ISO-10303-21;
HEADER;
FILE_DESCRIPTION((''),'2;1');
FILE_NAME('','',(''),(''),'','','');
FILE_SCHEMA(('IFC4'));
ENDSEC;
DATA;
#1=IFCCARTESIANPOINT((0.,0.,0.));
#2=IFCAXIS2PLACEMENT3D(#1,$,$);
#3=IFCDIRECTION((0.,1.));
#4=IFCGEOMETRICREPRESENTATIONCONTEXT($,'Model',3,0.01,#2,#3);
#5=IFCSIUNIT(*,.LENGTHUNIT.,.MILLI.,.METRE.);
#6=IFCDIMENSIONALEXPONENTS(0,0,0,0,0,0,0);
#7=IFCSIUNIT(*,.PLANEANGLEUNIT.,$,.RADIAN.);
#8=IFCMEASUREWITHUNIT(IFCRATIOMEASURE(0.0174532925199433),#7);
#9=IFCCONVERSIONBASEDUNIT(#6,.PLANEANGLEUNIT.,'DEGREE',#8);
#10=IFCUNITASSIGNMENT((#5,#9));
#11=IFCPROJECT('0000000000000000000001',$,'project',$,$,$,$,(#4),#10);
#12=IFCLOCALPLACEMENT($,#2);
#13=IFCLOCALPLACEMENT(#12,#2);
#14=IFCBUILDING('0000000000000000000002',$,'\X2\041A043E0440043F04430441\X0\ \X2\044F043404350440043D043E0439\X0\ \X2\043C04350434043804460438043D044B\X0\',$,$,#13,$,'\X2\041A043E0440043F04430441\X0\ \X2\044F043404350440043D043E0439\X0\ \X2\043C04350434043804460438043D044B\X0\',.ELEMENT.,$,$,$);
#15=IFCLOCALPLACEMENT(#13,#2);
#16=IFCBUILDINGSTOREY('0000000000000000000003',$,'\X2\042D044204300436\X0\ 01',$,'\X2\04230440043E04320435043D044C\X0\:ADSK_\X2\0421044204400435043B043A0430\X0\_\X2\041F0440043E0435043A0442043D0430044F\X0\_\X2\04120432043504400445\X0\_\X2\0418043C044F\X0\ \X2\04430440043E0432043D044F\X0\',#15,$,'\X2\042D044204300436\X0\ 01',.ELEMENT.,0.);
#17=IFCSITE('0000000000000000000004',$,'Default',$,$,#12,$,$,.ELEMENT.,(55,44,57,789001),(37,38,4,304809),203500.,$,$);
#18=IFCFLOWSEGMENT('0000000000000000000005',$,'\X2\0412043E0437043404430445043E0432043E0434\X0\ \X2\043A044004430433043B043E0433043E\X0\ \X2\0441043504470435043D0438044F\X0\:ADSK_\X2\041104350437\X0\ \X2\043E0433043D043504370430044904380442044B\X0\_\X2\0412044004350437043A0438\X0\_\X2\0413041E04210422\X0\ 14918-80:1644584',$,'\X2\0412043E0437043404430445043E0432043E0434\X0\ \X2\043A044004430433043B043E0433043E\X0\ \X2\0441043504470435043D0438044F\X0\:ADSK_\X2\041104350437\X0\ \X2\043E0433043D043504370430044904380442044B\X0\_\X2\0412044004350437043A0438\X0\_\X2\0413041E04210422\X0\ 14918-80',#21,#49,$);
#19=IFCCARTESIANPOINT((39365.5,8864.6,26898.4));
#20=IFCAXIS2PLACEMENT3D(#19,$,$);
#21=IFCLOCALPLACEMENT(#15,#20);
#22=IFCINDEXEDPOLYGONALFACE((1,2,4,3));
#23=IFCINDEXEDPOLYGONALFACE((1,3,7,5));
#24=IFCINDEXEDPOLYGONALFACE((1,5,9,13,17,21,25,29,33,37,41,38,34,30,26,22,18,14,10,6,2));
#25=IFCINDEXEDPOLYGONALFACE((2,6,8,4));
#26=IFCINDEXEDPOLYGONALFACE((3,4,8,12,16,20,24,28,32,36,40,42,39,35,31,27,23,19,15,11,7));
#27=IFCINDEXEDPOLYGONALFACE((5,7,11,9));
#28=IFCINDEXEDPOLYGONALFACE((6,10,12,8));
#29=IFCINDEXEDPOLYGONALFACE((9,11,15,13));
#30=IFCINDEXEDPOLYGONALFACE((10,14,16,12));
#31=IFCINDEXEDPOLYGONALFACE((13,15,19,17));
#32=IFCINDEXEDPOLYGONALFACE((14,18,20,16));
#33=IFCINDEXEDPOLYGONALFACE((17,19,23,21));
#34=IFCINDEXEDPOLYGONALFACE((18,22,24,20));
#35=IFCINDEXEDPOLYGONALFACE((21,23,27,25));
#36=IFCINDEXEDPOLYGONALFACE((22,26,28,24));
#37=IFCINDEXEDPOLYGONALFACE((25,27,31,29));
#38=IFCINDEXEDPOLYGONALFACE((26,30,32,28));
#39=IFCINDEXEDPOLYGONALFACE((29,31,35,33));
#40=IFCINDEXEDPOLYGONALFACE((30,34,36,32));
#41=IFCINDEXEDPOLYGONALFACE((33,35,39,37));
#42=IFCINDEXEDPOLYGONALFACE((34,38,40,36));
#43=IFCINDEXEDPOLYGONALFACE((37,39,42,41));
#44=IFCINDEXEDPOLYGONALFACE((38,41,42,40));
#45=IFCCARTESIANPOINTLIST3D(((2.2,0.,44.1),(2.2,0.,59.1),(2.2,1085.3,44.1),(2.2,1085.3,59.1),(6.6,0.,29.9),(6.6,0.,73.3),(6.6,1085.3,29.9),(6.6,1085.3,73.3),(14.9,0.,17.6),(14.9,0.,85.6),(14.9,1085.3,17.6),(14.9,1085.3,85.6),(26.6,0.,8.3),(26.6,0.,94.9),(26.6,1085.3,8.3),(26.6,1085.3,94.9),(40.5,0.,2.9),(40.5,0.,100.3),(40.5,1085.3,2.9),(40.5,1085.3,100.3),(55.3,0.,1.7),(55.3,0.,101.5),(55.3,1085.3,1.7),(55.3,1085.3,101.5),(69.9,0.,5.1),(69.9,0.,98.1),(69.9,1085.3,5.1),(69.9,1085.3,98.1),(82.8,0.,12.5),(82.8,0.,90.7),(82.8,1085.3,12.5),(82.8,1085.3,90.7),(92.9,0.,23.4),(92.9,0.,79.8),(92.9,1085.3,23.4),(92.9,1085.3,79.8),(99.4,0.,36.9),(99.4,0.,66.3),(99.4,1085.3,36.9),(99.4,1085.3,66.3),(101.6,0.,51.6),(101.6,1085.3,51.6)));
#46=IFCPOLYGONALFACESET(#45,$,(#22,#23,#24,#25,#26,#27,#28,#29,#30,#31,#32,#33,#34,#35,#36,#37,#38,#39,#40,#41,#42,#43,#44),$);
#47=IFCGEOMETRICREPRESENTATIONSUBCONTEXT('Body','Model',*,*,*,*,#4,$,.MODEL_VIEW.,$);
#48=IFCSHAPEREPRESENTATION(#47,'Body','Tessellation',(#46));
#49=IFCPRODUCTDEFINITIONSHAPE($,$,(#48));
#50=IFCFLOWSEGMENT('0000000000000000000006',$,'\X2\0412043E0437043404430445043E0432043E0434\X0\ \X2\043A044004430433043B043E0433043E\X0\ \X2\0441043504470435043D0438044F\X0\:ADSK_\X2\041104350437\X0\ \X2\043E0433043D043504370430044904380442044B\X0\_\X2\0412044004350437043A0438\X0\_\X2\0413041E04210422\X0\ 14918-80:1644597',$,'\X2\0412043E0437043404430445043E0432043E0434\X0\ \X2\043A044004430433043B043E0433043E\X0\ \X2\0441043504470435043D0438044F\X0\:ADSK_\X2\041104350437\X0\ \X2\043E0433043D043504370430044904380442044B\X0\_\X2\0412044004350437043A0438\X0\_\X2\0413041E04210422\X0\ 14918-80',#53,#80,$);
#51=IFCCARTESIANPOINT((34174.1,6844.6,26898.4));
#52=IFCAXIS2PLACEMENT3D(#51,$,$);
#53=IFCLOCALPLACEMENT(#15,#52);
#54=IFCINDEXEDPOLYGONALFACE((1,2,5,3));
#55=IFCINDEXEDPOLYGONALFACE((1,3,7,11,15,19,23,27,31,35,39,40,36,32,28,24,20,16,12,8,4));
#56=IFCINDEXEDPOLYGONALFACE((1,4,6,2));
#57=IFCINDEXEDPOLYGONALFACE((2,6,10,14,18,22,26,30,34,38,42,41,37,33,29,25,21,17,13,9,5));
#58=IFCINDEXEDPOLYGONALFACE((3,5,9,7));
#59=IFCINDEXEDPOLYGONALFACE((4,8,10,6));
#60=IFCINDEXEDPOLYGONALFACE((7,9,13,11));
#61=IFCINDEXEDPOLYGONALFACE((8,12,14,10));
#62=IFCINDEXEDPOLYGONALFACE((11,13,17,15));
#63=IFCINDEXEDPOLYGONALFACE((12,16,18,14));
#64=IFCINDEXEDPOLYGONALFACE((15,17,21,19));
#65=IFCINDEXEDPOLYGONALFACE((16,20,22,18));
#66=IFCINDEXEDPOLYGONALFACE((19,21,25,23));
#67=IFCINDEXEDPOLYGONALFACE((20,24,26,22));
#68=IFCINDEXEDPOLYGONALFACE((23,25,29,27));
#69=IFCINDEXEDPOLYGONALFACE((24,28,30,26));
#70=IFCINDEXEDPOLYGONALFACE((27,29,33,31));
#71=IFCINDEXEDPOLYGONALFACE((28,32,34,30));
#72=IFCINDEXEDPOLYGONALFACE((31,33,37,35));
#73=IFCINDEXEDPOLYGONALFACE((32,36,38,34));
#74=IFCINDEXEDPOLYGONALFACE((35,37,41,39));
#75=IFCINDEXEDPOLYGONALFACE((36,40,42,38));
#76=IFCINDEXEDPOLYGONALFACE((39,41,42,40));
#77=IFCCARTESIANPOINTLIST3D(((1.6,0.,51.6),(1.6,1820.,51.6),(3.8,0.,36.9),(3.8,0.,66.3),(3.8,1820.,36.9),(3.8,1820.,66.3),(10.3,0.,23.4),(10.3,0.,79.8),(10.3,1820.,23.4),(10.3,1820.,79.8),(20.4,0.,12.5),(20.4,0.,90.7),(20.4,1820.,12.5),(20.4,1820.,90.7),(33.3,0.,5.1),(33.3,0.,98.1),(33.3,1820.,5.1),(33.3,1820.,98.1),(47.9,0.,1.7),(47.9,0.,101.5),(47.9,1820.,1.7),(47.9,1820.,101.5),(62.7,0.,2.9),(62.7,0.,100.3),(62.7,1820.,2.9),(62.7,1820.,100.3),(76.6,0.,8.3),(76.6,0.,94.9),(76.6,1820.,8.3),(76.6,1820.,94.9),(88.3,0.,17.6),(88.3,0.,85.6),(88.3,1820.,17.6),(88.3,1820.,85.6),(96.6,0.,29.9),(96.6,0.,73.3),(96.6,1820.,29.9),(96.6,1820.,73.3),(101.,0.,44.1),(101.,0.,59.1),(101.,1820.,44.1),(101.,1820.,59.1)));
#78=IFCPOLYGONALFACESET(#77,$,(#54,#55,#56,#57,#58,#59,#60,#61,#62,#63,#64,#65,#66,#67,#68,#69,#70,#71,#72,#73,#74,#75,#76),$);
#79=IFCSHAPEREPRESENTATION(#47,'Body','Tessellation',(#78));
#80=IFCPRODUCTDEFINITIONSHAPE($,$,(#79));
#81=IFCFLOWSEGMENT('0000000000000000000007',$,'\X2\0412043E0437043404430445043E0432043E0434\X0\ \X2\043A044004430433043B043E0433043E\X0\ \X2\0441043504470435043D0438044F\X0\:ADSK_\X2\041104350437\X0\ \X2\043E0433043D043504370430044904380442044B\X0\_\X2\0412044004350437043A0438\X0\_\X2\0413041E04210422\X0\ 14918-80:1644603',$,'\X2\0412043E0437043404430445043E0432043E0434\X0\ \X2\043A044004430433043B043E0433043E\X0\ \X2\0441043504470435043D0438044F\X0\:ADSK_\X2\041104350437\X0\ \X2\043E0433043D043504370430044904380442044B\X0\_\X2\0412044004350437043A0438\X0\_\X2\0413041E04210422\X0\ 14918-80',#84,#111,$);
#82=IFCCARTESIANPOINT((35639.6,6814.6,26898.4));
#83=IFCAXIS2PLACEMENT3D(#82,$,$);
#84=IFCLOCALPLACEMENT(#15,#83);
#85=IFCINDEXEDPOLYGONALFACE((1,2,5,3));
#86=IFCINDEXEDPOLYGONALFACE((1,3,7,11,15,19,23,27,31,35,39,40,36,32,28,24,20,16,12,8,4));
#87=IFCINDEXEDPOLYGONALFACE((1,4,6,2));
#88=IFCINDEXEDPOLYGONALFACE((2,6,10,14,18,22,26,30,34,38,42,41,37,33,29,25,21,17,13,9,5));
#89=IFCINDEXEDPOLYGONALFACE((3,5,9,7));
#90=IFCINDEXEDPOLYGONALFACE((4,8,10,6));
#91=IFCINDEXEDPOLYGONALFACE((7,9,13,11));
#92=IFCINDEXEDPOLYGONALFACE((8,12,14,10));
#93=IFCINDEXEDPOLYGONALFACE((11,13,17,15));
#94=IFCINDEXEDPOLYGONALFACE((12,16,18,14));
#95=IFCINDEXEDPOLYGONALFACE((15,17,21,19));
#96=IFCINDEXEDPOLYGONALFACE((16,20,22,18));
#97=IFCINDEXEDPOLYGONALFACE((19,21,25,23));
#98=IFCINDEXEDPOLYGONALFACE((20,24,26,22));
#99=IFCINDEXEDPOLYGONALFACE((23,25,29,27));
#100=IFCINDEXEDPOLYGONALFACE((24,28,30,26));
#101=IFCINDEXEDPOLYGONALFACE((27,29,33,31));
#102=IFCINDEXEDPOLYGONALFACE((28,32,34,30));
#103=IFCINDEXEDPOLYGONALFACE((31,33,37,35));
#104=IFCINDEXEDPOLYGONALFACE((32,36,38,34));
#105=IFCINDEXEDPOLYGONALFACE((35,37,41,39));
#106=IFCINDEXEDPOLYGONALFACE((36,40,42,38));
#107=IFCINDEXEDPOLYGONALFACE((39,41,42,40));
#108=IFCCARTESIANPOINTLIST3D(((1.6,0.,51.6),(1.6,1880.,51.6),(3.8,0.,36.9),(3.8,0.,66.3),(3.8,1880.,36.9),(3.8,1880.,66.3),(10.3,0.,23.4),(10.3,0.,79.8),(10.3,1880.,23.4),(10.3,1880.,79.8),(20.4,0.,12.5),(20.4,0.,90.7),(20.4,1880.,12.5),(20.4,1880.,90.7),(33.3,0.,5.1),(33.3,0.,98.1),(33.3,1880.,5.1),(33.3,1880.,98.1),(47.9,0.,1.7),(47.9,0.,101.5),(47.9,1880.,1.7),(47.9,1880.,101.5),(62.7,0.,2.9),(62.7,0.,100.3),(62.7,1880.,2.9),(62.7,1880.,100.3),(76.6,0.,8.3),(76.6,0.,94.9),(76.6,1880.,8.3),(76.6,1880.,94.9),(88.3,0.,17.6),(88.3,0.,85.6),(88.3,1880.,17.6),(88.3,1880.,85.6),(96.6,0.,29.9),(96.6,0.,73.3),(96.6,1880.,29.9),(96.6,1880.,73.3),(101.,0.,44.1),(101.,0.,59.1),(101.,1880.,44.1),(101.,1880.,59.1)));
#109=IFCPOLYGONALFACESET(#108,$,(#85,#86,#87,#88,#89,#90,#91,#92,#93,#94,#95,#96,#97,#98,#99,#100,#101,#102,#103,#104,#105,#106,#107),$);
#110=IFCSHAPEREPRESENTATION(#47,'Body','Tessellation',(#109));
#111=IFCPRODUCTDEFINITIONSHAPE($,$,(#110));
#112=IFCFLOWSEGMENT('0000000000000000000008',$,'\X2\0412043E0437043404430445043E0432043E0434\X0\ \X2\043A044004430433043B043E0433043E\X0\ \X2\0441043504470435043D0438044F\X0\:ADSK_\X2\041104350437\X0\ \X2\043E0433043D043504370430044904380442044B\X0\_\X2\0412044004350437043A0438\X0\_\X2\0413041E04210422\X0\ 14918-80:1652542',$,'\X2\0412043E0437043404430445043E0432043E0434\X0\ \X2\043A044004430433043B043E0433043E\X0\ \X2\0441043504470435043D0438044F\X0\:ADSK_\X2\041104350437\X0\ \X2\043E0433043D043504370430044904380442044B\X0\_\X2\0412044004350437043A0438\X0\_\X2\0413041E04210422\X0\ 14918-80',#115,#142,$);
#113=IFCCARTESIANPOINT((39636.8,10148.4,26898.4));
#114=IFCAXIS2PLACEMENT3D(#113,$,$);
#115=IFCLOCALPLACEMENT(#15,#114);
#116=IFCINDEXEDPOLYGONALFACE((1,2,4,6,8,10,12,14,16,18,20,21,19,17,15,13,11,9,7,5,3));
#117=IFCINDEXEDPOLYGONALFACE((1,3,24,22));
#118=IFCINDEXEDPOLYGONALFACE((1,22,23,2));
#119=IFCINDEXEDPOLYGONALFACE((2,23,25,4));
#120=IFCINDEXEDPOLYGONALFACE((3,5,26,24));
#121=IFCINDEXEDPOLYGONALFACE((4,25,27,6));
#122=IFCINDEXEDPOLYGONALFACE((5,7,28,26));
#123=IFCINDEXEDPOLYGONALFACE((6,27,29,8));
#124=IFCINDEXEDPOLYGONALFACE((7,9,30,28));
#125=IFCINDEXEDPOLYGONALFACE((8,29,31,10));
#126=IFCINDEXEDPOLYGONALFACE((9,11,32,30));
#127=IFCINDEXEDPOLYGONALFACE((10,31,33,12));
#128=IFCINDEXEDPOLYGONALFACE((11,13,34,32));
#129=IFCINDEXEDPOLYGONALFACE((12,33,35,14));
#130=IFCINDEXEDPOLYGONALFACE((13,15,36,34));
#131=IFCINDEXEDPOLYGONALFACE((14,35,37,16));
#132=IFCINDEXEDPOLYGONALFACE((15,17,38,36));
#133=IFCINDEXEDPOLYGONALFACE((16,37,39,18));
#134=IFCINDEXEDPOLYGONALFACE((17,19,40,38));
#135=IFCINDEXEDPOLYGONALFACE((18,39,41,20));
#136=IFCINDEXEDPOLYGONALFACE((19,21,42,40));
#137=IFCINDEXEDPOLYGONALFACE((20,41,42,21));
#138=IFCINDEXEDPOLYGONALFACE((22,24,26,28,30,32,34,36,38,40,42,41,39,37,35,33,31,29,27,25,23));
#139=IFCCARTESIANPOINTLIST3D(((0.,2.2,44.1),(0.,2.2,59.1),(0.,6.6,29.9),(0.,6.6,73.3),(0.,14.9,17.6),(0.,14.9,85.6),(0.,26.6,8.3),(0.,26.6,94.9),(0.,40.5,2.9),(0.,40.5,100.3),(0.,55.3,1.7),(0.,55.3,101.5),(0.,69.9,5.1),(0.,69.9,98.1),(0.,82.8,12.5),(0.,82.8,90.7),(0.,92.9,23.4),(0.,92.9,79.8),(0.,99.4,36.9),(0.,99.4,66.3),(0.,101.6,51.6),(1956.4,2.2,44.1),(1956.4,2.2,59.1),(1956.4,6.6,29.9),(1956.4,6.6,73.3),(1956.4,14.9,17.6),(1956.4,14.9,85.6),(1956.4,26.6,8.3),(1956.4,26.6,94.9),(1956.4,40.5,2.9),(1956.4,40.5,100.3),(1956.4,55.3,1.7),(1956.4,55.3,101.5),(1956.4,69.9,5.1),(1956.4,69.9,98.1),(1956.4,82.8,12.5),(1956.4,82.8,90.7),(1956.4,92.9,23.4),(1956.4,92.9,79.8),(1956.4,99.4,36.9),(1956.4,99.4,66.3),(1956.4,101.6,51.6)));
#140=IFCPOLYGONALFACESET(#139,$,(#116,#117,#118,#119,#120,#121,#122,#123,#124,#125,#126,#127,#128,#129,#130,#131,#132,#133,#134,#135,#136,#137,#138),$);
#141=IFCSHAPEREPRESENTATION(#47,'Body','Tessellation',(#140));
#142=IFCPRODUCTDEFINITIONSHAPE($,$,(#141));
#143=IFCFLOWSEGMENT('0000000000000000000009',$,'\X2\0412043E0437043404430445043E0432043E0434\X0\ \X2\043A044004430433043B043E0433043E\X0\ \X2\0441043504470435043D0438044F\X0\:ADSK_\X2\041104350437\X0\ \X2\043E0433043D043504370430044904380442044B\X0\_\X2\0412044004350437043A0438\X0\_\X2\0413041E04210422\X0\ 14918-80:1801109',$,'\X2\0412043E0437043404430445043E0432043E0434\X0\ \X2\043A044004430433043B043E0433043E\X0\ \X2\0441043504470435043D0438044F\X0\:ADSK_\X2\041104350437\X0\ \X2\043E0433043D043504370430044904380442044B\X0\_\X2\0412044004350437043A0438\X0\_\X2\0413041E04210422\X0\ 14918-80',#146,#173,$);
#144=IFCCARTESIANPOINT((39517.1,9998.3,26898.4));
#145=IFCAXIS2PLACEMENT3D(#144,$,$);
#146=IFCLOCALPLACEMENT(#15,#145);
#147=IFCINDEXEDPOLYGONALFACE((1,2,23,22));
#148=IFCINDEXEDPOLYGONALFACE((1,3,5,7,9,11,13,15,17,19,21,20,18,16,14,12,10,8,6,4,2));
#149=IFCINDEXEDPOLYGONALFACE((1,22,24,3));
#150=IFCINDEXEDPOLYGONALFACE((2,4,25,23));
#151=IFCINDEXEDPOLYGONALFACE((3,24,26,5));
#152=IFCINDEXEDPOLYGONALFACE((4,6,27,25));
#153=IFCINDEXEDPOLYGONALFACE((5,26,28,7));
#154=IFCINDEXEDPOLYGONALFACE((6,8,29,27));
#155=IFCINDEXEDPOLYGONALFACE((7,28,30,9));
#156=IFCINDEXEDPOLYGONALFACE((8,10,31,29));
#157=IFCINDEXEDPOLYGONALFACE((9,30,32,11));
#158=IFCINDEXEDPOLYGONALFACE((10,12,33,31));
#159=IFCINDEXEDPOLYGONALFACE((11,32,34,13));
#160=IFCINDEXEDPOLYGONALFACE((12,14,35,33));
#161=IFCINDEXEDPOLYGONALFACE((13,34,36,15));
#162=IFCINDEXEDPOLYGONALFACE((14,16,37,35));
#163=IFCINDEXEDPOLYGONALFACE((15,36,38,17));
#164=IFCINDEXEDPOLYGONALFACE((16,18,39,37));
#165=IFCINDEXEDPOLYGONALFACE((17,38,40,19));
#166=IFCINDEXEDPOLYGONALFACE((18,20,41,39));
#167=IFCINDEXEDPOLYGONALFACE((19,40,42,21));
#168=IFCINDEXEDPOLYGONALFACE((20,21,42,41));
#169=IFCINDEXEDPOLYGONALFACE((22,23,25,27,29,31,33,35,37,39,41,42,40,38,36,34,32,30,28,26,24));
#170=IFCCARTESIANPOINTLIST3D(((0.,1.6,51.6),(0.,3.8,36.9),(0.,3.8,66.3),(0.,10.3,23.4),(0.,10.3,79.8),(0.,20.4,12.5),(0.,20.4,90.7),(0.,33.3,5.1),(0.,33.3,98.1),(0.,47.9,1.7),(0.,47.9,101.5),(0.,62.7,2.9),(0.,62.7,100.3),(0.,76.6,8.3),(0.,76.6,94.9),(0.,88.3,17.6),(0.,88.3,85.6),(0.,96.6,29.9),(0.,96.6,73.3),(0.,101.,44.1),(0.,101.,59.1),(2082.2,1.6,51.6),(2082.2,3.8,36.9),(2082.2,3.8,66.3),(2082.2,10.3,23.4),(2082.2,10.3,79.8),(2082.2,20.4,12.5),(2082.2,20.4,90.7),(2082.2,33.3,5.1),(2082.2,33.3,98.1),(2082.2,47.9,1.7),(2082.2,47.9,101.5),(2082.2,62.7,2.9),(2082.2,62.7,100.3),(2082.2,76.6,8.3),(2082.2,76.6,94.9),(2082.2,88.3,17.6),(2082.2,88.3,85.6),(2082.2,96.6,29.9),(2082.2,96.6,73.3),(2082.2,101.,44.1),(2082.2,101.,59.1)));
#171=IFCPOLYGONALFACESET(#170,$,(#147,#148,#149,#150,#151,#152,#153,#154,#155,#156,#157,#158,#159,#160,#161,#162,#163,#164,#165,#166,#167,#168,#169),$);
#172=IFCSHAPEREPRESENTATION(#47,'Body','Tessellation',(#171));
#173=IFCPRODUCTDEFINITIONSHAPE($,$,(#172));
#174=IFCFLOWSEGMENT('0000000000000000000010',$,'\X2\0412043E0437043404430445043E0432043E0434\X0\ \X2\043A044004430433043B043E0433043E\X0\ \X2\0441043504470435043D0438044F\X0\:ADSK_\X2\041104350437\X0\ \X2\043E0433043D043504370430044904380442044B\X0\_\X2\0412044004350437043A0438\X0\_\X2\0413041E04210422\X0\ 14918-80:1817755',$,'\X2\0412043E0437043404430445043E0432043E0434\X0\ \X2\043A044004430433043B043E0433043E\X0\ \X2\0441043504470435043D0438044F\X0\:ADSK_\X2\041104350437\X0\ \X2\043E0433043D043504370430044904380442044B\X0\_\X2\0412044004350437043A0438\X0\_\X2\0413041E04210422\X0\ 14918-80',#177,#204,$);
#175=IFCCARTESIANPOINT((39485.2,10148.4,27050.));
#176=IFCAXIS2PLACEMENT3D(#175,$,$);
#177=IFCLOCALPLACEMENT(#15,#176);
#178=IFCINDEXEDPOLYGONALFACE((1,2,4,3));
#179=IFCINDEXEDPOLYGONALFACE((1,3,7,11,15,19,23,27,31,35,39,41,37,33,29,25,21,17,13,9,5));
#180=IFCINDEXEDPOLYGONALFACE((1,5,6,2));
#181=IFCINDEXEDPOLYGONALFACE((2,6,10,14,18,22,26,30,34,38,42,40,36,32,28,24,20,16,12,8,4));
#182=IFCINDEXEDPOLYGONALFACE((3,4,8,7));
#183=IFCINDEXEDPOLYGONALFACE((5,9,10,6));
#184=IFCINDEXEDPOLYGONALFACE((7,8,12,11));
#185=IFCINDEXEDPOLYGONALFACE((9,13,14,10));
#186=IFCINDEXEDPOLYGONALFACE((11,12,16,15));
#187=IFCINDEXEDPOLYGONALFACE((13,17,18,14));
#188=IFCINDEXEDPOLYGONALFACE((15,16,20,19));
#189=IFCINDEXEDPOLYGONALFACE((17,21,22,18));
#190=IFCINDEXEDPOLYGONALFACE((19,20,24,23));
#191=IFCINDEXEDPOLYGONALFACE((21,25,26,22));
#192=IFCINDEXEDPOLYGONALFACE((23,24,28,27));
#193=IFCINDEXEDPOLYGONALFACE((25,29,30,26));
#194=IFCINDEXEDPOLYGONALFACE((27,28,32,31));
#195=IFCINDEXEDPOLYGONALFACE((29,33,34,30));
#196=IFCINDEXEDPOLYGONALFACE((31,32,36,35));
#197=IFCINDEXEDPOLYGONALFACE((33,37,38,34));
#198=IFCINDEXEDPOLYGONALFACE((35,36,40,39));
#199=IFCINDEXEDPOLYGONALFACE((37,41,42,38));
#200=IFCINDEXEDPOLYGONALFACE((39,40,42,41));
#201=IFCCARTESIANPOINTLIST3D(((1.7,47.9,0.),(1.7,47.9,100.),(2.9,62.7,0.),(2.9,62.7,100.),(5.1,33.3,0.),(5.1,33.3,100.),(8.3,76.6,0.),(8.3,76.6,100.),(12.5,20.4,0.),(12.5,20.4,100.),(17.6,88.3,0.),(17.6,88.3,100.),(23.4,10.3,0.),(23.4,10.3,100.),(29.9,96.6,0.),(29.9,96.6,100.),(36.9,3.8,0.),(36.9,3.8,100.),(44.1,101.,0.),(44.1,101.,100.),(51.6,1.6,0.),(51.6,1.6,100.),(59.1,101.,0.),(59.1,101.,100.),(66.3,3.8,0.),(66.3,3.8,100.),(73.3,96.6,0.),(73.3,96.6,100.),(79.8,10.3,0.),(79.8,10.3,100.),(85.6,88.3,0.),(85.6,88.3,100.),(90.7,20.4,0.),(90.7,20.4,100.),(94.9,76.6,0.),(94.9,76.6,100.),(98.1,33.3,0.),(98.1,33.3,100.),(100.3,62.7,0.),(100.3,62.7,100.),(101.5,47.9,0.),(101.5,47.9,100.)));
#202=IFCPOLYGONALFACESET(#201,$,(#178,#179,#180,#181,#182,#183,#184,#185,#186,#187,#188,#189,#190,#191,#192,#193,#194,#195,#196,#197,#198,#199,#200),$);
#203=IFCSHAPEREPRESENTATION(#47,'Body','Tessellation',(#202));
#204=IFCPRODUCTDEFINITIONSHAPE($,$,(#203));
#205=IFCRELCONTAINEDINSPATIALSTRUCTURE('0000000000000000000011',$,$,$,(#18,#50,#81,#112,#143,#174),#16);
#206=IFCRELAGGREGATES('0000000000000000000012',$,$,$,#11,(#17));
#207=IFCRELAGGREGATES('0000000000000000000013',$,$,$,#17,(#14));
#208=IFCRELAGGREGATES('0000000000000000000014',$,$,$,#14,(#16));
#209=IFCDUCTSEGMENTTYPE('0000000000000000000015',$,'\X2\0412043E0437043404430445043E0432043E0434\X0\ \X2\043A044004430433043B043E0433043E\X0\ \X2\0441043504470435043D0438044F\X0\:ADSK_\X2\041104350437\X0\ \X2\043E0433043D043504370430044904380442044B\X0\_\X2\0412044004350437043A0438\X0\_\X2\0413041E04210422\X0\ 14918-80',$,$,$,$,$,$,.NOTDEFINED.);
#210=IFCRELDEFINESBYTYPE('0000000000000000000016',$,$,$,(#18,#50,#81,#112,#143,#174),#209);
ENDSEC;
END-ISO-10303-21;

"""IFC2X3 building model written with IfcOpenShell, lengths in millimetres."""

from ifc_helpers import new_model, entity, si_unit, converted_unit, direction, frame, origin, origin_2d_with_axis, place, context, subcontext, project, spatial, circle, extrude, type_object, element, save


model = new_model("IFC2X3")

# Units and contexts
model_context = context("Model", 3, precision=0.01, world=origin(), true_north=direction((0.0, 1.0)))
body_context = subcontext(model_context, "Body", "Model", "MODEL_VIEW")
ifc_project = project(units=[si_unit("LENGTHUNIT", "METRE", prefix="MILLI"), converted_unit("PLANEANGLEUNIT", "DEGREE", entity("IfcRatioMeasure", 0.0174532925199433), si_unit("PLANEANGLEUNIT", "RADIAN"), dimensions=[0, 0, 0, 0, 0, 0, 0])], contexts=[model_context])

# Site, building, storey
site_placement = place(None, origin())
site = spatial("IfcSite", under=ifc_project, at=site_placement, Name="Default", CompositionType="ELEMENT", RefLatitude=(55, 44, 57, 789001), RefLongitude=(37, 38, 4, 304809), RefElevation=203500.0)
building_placement = place(site_placement, origin())
building = spatial("IfcBuilding", under=site, at=building_placement, Name="Корпус ядерной медицины", LongName="Корпус ядерной медицины", CompositionType="ELEMENT")
storey_placement = place(building_placement, origin())
storey = spatial("IfcBuildingStorey", under=building, at=storey_placement, Name="Этаж 01", ObjectType="Уровень:ADSK_Стрелка_Проектная_Вверх_Имя уровня", LongName="Этаж 01", CompositionType="ELEMENT", Elevation=0.0)

# Flow segments
duct_segment_type_1 = type_object("IfcDuctSegmentType", Name="Воздуховод круглого сечения:ADSK_Без огнезащиты_Врезки_ГОСТ 14918-80", PredefinedType="NOTDEFINED")
flow_segment_1_placement = place(storey_placement, frame((39365.5, 8864.6, 26898.4)))
element("IfcFlowSegment", 1, at=flow_segment_1_placement, inside=storey, type_object=duct_segment_type_1, Name="Воздуховод круглого сечения:ADSK_Без огнезащиты_Врезки_ГОСТ 14918-80:1644584", ObjectType="Воздуховод круглого сечения:ADSK_Без огнезащиты_Врезки_ГОСТ 14918-80", context=body_context, shape_type="SweptSolid", body=[
    extrude(circle(Radius=50.0, at=origin_2d_with_axis()), frame((51.6, 0.0, 51.6), z_axis=(0.0, 1.0, 0.0), x_axis=(1.0, 0.0, 0.0)), (0.0, 0.0, 1.0), 1085.3),
])
flow_segment_2_placement = place(storey_placement, frame((34174.1, 6844.6, 26898.4)))
element("IfcFlowSegment", 2, at=flow_segment_2_placement, inside=storey, type_object=duct_segment_type_1, Name="Воздуховод круглого сечения:ADSK_Без огнезащиты_Врезки_ГОСТ 14918-80:1644597", ObjectType="Воздуховод круглого сечения:ADSK_Без огнезащиты_Врезки_ГОСТ 14918-80", context=body_context, shape_type="SweptSolid", body=[
    extrude(circle(Radius=50.0, at=origin_2d_with_axis()), frame((51.6, 0.0, 51.6), z_axis=(0.0, 1.0, 0.0), x_axis=(-1.0, 0.0, 0.0)), (0.0, 0.0, 1.0), 1820.0),
])
flow_segment_3_placement = place(storey_placement, frame((35639.6, 6814.6, 26898.4)))
element("IfcFlowSegment", 3, at=flow_segment_3_placement, inside=storey, type_object=duct_segment_type_1, Name="Воздуховод круглого сечения:ADSK_Без огнезащиты_Врезки_ГОСТ 14918-80:1644603", ObjectType="Воздуховод круглого сечения:ADSK_Без огнезащиты_Врезки_ГОСТ 14918-80", context=body_context, shape_type="SweptSolid", body=[
    extrude(circle(Radius=50.0, at=origin_2d_with_axis()), frame((51.6, 0.0, 51.6), z_axis=(0.0, 1.0, 0.0), x_axis=(-1.0, 0.0, 0.0)), (0.0, 0.0, 1.0), 1880.0),
])
flow_segment_4_placement = place(storey_placement, frame((39636.8, 10148.4, 26898.4)))
element("IfcFlowSegment", 4, at=flow_segment_4_placement, inside=storey, type_object=duct_segment_type_1, Name="Воздуховод круглого сечения:ADSK_Без огнезащиты_Врезки_ГОСТ 14918-80:1652542", ObjectType="Воздуховод круглого сечения:ADSK_Без огнезащиты_Врезки_ГОСТ 14918-80", context=body_context, shape_type="SweptSolid", body=[
    extrude(circle(Radius=50.0, at=origin_2d_with_axis()), frame((0.0, 51.6, 51.6), z_axis=(1.0, 0.0, 0.0), x_axis=(0.0, 1.0, 0.0)), (0.0, 0.0, 1.0), 1956.4),
])
flow_segment_5_placement = place(storey_placement, frame((39517.1, 9998.3, 26898.4)))
element("IfcFlowSegment", 5, at=flow_segment_5_placement, inside=storey, type_object=duct_segment_type_1, Name="Воздуховод круглого сечения:ADSK_Без огнезащиты_Врезки_ГОСТ 14918-80:1801109", ObjectType="Воздуховод круглого сечения:ADSK_Без огнезащиты_Врезки_ГОСТ 14918-80", context=body_context, shape_type="SweptSolid", body=[
    extrude(circle(Radius=50.0, at=origin_2d_with_axis()), frame((0.0, 51.6, 51.6), z_axis=(1.0, 0.0, 0.0), x_axis=(0.0, -1.0, 0.0)), (0.0, 0.0, 1.0), 2082.2),
])
flow_segment_6_placement = place(storey_placement, frame((39485.2, 10148.4, 27050.0)))
element("IfcFlowSegment", 6, at=flow_segment_6_placement, inside=storey, type_object=duct_segment_type_1, Name="Воздуховод круглого сечения:ADSK_Без огнезащиты_Врезки_ГОСТ 14918-80:1817755", ObjectType="Воздуховод круглого сечения:ADSK_Без огнезащиты_Врезки_ГОСТ 14918-80", context=body_context, shape_type="SweptSolid", body=[
    extrude(circle(Radius=50.0, at=origin_2d_with_axis()), frame((51.6, 51.6, 0.0), z_axis=(0.0, 0.0, 1.0), x_axis=(0.0, -1.0, 0.0)), (0.0, 0.0, 1.0), 100.0),
])

save(model, "model.ifc")
